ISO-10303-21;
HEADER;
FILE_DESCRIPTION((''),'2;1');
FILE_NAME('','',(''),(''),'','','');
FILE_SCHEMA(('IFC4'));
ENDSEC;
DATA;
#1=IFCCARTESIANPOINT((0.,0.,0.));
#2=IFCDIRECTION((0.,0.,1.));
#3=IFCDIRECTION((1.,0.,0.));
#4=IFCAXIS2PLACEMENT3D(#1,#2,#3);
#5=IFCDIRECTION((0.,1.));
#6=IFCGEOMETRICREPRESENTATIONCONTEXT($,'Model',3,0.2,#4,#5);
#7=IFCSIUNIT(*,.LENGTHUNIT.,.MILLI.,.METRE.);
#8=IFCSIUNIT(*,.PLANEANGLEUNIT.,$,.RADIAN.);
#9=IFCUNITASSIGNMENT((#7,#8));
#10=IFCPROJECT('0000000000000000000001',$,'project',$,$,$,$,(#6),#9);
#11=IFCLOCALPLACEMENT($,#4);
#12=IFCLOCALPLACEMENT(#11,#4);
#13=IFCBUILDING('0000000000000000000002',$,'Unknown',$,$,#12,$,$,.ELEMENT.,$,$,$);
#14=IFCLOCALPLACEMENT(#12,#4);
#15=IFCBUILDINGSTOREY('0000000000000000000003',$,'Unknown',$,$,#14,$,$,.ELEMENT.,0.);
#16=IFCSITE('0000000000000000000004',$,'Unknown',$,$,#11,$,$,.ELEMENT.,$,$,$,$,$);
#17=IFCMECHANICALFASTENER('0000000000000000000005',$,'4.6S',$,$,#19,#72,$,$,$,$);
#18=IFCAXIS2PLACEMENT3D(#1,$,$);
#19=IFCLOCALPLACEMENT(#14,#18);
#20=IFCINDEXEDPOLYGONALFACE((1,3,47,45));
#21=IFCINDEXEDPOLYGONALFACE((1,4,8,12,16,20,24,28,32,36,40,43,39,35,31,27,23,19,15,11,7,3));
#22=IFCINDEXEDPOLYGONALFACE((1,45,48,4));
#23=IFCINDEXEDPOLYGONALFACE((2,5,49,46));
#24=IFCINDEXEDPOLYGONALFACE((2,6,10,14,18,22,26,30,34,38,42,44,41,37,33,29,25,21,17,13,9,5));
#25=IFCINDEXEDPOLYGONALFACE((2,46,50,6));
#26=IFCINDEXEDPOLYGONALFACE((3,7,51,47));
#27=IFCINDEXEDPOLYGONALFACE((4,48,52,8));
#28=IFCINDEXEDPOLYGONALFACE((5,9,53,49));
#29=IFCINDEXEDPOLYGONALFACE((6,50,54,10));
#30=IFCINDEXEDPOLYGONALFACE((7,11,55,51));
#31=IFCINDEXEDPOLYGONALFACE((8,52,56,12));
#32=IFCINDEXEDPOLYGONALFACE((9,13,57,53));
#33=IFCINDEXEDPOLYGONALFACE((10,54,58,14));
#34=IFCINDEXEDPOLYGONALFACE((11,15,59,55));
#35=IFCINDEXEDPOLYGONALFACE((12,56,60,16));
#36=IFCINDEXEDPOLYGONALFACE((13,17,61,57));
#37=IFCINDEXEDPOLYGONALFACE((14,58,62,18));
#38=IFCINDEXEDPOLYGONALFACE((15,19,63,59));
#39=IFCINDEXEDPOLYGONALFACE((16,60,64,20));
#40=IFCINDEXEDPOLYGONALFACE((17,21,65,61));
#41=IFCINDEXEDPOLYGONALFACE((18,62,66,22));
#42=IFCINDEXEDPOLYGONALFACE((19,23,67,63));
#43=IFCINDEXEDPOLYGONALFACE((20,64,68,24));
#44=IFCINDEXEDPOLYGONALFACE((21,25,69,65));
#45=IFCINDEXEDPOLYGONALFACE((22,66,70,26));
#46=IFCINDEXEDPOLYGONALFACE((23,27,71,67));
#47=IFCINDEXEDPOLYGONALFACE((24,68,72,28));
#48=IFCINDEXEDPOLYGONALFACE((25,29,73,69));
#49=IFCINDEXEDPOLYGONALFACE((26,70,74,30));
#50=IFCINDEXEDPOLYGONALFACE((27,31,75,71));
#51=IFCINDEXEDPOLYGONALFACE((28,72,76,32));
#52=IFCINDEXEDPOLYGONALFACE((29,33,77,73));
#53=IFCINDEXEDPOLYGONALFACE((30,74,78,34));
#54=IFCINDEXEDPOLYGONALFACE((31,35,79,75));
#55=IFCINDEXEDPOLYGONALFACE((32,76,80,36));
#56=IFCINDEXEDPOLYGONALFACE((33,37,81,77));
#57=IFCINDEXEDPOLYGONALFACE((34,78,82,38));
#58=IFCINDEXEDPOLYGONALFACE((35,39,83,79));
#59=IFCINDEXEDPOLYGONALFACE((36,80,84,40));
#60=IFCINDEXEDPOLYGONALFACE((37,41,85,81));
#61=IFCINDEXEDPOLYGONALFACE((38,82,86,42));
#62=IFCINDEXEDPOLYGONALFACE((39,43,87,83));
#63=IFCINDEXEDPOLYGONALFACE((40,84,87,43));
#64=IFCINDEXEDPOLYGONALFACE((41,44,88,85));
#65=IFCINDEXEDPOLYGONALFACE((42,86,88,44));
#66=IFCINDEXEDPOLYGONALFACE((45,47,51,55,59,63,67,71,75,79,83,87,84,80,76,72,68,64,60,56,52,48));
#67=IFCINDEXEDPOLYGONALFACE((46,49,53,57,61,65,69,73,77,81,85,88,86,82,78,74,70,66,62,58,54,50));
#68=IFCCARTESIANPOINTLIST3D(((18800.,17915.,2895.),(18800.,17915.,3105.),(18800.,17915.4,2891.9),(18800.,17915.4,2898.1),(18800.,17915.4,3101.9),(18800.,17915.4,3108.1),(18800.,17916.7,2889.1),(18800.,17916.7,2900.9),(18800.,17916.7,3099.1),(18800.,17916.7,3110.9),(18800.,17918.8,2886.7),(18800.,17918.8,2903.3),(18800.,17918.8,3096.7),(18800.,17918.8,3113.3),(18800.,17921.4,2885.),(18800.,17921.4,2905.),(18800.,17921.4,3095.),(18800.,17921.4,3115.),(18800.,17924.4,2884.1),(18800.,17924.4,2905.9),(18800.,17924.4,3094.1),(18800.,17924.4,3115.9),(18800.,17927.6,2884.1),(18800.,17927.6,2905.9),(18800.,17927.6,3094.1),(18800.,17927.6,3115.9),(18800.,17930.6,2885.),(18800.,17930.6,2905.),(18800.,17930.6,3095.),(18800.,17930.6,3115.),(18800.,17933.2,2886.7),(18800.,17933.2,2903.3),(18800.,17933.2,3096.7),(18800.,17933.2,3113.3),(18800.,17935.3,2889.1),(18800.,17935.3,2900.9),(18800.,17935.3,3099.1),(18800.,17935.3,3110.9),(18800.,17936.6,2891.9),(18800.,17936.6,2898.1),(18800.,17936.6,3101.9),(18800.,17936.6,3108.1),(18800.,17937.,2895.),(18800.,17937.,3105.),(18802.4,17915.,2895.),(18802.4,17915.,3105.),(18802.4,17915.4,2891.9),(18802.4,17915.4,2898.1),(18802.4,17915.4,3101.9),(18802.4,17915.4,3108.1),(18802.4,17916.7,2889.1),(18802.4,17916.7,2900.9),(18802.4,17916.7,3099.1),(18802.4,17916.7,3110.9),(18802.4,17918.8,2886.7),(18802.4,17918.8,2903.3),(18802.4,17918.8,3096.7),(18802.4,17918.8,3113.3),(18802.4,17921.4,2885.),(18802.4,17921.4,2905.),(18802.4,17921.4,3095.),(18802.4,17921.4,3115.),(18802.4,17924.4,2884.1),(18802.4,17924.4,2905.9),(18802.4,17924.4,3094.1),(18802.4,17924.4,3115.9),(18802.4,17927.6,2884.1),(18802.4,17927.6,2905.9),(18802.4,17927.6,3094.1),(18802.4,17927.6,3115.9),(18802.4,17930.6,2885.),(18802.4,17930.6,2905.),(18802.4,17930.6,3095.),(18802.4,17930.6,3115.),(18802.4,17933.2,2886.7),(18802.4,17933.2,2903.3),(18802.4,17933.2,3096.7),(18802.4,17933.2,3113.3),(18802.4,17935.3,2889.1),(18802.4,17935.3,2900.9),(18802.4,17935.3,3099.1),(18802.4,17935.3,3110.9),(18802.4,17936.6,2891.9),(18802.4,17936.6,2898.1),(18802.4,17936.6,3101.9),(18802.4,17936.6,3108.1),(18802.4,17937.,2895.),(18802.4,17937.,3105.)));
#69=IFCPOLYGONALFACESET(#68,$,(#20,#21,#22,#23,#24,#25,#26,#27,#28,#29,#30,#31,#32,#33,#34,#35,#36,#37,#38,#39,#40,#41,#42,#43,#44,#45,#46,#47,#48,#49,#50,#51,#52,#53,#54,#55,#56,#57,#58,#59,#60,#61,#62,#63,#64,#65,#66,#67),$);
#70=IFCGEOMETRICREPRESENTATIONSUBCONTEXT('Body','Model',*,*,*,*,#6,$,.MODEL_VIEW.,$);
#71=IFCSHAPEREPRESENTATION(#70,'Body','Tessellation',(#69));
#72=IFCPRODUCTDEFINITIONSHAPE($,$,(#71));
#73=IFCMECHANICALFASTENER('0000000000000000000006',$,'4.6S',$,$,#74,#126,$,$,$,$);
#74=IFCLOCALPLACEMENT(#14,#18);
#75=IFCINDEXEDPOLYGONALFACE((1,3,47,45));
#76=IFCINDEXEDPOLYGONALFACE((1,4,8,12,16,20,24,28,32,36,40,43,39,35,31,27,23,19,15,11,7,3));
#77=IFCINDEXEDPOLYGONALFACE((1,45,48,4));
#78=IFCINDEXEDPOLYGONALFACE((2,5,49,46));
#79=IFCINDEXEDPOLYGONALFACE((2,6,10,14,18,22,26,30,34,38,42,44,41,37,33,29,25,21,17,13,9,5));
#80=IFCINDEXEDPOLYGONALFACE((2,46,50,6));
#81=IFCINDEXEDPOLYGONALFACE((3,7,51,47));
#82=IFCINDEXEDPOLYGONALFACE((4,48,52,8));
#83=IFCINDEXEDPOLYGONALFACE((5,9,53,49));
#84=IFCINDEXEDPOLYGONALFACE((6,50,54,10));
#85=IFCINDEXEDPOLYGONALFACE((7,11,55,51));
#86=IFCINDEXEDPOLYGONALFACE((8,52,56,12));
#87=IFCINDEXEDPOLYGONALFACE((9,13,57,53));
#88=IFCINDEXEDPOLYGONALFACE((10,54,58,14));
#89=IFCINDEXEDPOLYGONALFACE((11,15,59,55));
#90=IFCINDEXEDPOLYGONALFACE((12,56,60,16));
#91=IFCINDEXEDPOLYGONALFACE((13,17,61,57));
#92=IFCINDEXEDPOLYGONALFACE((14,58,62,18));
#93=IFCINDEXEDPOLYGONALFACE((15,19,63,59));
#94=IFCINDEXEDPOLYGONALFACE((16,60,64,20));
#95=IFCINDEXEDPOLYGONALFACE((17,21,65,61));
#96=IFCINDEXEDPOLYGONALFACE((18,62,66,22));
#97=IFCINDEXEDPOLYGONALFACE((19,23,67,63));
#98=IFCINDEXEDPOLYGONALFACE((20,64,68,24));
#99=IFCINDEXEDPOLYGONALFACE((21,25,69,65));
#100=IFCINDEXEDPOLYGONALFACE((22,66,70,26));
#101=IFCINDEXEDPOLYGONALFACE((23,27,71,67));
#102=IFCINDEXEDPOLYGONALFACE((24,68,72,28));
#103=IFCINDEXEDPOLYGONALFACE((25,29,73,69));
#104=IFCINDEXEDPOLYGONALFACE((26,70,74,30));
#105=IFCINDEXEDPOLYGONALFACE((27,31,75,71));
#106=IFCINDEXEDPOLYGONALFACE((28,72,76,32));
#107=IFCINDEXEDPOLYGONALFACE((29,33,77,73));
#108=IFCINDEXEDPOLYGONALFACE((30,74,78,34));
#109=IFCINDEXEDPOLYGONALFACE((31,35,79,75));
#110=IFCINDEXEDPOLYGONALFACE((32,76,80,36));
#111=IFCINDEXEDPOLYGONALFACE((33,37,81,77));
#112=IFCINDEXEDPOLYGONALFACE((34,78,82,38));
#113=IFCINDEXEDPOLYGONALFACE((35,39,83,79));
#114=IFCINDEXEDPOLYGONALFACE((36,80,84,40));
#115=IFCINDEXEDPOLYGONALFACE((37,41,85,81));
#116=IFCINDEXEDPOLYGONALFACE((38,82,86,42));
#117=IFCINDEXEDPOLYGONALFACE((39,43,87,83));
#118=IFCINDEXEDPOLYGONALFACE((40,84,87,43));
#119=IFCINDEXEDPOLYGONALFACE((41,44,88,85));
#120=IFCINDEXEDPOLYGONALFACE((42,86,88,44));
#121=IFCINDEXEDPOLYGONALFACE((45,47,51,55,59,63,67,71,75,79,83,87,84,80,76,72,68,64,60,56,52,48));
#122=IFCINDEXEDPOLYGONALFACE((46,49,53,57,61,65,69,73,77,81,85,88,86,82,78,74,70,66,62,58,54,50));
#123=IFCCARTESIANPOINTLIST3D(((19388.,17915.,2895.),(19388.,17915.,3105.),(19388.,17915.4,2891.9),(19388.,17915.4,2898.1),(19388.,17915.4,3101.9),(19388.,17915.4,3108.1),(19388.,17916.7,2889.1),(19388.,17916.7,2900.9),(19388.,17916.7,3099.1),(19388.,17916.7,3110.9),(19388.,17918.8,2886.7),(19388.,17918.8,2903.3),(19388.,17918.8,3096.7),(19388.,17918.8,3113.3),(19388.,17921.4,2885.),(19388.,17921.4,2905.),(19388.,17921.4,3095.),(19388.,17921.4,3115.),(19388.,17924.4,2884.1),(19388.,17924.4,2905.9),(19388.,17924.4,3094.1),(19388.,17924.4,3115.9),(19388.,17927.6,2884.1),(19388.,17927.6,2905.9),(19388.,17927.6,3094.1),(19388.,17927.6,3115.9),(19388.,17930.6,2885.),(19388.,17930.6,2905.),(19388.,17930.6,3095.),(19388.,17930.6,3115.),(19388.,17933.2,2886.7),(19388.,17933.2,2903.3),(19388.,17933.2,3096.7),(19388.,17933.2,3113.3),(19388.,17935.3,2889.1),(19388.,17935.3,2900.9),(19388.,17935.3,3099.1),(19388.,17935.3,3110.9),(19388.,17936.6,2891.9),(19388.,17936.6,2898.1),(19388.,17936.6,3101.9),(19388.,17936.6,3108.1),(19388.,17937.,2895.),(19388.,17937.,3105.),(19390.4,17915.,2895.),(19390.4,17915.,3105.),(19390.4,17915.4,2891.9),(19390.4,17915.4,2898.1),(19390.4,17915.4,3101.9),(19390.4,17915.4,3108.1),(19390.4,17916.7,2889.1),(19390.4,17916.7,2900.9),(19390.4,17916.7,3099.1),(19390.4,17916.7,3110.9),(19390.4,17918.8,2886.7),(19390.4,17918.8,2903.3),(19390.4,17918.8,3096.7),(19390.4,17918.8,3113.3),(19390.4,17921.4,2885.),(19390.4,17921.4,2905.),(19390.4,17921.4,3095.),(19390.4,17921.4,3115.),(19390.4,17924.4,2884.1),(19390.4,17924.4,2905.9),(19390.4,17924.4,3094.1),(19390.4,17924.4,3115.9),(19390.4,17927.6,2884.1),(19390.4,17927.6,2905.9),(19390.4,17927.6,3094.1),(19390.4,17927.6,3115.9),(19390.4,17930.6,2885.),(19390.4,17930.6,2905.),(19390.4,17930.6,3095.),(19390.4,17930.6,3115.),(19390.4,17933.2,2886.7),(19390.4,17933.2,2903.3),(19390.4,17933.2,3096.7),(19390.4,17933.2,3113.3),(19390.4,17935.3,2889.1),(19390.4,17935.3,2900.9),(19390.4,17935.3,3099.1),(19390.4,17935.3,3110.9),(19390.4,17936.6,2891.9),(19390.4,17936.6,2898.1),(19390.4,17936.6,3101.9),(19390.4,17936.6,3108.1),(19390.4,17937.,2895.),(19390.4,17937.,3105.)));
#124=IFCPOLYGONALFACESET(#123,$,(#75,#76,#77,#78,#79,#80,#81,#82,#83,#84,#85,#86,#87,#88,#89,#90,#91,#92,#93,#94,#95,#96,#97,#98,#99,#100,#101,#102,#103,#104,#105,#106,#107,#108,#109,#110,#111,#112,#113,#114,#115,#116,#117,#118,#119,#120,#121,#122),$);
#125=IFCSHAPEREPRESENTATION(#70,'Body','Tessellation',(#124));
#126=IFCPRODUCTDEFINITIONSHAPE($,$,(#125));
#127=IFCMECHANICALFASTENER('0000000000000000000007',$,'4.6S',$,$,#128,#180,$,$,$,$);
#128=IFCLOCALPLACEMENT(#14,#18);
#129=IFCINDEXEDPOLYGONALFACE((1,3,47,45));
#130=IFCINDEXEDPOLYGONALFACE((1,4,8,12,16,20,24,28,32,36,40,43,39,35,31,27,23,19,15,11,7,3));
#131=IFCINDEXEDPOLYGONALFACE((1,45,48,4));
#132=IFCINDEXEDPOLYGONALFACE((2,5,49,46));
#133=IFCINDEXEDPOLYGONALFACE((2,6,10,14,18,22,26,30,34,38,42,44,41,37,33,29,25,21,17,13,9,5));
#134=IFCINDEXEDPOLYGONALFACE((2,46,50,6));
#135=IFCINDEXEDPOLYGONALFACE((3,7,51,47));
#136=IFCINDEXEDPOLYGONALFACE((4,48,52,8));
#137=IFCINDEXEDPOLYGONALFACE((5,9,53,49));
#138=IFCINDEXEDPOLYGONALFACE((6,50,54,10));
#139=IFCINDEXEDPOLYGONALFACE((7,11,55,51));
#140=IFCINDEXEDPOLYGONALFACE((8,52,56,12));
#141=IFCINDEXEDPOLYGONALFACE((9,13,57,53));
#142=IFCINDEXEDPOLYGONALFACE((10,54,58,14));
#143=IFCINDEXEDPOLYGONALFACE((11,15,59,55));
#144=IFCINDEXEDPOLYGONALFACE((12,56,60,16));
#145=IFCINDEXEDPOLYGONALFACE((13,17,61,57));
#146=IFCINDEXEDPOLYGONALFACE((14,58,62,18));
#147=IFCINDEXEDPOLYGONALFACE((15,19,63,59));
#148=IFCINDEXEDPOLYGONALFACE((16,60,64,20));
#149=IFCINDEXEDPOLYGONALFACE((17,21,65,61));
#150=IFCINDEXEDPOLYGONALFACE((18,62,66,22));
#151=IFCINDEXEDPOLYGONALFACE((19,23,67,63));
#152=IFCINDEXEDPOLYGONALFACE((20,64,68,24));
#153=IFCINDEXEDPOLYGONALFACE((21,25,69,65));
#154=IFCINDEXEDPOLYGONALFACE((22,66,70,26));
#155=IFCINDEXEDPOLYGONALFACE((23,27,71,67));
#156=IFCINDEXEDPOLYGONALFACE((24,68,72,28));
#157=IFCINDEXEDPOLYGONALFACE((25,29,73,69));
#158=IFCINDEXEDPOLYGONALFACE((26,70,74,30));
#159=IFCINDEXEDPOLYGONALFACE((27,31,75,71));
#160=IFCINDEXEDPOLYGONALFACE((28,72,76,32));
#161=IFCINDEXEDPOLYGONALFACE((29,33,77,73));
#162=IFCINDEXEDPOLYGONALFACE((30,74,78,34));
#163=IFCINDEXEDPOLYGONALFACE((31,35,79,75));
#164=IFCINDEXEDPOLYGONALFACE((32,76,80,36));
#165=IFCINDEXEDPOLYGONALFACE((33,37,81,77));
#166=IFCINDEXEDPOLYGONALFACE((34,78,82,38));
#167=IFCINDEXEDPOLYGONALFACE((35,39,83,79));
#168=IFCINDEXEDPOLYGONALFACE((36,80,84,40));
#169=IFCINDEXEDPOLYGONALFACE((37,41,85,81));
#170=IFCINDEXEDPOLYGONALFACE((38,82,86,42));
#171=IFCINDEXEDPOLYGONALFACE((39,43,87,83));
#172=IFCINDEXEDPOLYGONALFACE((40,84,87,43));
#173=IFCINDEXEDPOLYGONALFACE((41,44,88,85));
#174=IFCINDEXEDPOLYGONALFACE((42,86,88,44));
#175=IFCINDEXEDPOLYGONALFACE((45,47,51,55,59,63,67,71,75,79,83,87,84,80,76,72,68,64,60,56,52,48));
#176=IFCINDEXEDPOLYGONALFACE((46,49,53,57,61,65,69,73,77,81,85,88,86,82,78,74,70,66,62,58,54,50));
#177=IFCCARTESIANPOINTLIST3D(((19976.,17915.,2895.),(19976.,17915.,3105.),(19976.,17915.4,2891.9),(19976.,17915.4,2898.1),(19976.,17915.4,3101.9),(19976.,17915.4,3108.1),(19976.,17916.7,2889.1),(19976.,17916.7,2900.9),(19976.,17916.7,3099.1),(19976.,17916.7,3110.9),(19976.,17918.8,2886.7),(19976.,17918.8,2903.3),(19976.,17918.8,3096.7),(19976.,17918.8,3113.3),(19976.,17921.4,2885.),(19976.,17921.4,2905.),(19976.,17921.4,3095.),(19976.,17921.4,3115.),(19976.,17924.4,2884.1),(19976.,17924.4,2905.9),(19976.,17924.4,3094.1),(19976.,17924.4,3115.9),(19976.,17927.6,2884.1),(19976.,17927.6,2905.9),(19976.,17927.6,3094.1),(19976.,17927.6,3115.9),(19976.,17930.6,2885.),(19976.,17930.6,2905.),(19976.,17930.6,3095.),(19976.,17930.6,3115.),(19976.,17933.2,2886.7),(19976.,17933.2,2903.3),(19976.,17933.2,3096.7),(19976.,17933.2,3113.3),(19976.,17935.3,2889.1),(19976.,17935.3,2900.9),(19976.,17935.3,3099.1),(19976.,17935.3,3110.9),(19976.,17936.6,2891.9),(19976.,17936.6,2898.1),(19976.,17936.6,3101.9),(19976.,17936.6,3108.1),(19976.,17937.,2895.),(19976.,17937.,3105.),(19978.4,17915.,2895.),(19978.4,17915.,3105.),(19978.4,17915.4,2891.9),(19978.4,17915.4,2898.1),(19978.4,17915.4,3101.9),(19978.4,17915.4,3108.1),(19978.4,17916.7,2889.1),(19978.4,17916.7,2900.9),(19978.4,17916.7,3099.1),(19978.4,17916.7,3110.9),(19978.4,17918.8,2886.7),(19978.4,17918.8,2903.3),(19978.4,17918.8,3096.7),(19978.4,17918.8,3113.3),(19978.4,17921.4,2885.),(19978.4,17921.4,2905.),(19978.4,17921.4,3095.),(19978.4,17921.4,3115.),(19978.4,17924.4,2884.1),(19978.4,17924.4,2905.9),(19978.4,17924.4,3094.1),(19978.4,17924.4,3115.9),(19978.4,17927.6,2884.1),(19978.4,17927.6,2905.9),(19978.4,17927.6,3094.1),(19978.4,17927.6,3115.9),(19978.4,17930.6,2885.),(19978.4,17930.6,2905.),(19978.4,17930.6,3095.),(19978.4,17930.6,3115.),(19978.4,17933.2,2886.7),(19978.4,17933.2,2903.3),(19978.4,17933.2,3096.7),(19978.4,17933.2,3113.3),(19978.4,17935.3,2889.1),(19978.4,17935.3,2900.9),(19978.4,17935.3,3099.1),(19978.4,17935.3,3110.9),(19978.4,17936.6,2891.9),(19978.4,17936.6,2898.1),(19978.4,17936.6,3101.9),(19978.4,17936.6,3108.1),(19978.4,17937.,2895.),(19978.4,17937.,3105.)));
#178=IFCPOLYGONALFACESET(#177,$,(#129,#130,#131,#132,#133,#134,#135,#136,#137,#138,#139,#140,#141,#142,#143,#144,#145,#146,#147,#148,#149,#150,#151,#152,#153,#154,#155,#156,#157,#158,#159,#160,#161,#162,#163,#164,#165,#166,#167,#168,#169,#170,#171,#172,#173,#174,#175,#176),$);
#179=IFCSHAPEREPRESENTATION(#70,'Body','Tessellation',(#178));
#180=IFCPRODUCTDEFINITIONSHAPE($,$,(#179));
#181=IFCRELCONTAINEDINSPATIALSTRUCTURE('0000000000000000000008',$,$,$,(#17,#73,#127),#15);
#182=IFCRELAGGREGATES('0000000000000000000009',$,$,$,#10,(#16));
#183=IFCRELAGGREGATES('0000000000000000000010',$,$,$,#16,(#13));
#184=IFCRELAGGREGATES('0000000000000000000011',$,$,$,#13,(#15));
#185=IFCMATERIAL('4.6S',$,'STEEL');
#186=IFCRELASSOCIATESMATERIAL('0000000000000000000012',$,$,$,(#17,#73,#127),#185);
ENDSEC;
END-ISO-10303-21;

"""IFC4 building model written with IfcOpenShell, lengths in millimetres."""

from ifc_helpers import new_model, si_unit, direction, frame, origin_with_axes, place, context, subcontext, project, spatial, arc, indexed_curve, outline, extrude, source, transform, mapped, material, element, save


model = new_model("IFC4")

# Units and contexts
model_context = context("Model", 3, precision=0.2, world=origin_with_axes(), true_north=direction((0.0, 1.0)))
body_context = subcontext(model_context, "Body", "Model", "MODEL_VIEW")
ifc_project = project(units=[si_unit("LENGTHUNIT", "METRE", prefix="MILLI"), si_unit("PLANEANGLEUNIT", "RADIAN")], contexts=[model_context])

# Site, building, storey
site_placement = place(None, origin_with_axes())
site = spatial("IfcSite", under=ifc_project, at=site_placement, Name="Unknown", CompositionType="ELEMENT")
building_placement = place(site_placement, origin_with_axes())
building = spatial("IfcBuilding", under=site, at=building_placement, Name="Unknown", CompositionType="ELEMENT")
storey_placement = place(building_placement, origin_with_axes())
storey = spatial("IfcBuildingStorey", under=building, at=storey_placement, Name="Unknown", CompositionType="ELEMENT", Elevation=0.0)

# Mechanical fasteners
ifc_material_1 = material(Name="4.6S", Category="STEEL")
shared_shape_1 = source(origin_with_axes(), body_context, "Body", "SweptSolid", [
    extrude(outline(indexed_curve([(11.0, 0.0), (0.0, 11.0), (-11.0, 0.0), (0.0, -11.0)], segments=[arc(1, 2, 3), arc(3, 4, 1)])), frame((0.0, 0.0, 1.2), z_axis=(0.0, 0.0, -1.0), x_axis=(0.0, 1.0, 0.0)), (0.0, 0.0, 1.0), 2.4),
])
for number, where, z_axis, x_axis, name in (
    (1, (18801.2, 17926.0, 2895.0), (-1.0, 0.0, 0.0), (0.0, 0.0, 1.0), "4.6S"),
    (2, (19389.2, 17926.0, 2895.0), (-1.0, 0.0, 0.0), (0.0, 0.0, 1.0), "4.6S"),
    (3, (19977.2, 17926.0, 2895.0), (-1.0, 0.0, 0.0), (0.0, 0.0, 1.0), "4.6S"),
):
    element("IfcMechanicalFastener", number, at=place(storey_placement, frame(where, z_axis=z_axis, x_axis=x_axis)), inside=storey, material=ifc_material_1, Name=name, context=body_context, shape_type="MappedRepresentation", body=[
        mapped(shared_shape_1, transform((0.0, 0.0, 0.0))),
        mapped(shared_shape_1, transform((210.0, 0.0, 0.0))),
    ])

save(model, "model.ifc")
